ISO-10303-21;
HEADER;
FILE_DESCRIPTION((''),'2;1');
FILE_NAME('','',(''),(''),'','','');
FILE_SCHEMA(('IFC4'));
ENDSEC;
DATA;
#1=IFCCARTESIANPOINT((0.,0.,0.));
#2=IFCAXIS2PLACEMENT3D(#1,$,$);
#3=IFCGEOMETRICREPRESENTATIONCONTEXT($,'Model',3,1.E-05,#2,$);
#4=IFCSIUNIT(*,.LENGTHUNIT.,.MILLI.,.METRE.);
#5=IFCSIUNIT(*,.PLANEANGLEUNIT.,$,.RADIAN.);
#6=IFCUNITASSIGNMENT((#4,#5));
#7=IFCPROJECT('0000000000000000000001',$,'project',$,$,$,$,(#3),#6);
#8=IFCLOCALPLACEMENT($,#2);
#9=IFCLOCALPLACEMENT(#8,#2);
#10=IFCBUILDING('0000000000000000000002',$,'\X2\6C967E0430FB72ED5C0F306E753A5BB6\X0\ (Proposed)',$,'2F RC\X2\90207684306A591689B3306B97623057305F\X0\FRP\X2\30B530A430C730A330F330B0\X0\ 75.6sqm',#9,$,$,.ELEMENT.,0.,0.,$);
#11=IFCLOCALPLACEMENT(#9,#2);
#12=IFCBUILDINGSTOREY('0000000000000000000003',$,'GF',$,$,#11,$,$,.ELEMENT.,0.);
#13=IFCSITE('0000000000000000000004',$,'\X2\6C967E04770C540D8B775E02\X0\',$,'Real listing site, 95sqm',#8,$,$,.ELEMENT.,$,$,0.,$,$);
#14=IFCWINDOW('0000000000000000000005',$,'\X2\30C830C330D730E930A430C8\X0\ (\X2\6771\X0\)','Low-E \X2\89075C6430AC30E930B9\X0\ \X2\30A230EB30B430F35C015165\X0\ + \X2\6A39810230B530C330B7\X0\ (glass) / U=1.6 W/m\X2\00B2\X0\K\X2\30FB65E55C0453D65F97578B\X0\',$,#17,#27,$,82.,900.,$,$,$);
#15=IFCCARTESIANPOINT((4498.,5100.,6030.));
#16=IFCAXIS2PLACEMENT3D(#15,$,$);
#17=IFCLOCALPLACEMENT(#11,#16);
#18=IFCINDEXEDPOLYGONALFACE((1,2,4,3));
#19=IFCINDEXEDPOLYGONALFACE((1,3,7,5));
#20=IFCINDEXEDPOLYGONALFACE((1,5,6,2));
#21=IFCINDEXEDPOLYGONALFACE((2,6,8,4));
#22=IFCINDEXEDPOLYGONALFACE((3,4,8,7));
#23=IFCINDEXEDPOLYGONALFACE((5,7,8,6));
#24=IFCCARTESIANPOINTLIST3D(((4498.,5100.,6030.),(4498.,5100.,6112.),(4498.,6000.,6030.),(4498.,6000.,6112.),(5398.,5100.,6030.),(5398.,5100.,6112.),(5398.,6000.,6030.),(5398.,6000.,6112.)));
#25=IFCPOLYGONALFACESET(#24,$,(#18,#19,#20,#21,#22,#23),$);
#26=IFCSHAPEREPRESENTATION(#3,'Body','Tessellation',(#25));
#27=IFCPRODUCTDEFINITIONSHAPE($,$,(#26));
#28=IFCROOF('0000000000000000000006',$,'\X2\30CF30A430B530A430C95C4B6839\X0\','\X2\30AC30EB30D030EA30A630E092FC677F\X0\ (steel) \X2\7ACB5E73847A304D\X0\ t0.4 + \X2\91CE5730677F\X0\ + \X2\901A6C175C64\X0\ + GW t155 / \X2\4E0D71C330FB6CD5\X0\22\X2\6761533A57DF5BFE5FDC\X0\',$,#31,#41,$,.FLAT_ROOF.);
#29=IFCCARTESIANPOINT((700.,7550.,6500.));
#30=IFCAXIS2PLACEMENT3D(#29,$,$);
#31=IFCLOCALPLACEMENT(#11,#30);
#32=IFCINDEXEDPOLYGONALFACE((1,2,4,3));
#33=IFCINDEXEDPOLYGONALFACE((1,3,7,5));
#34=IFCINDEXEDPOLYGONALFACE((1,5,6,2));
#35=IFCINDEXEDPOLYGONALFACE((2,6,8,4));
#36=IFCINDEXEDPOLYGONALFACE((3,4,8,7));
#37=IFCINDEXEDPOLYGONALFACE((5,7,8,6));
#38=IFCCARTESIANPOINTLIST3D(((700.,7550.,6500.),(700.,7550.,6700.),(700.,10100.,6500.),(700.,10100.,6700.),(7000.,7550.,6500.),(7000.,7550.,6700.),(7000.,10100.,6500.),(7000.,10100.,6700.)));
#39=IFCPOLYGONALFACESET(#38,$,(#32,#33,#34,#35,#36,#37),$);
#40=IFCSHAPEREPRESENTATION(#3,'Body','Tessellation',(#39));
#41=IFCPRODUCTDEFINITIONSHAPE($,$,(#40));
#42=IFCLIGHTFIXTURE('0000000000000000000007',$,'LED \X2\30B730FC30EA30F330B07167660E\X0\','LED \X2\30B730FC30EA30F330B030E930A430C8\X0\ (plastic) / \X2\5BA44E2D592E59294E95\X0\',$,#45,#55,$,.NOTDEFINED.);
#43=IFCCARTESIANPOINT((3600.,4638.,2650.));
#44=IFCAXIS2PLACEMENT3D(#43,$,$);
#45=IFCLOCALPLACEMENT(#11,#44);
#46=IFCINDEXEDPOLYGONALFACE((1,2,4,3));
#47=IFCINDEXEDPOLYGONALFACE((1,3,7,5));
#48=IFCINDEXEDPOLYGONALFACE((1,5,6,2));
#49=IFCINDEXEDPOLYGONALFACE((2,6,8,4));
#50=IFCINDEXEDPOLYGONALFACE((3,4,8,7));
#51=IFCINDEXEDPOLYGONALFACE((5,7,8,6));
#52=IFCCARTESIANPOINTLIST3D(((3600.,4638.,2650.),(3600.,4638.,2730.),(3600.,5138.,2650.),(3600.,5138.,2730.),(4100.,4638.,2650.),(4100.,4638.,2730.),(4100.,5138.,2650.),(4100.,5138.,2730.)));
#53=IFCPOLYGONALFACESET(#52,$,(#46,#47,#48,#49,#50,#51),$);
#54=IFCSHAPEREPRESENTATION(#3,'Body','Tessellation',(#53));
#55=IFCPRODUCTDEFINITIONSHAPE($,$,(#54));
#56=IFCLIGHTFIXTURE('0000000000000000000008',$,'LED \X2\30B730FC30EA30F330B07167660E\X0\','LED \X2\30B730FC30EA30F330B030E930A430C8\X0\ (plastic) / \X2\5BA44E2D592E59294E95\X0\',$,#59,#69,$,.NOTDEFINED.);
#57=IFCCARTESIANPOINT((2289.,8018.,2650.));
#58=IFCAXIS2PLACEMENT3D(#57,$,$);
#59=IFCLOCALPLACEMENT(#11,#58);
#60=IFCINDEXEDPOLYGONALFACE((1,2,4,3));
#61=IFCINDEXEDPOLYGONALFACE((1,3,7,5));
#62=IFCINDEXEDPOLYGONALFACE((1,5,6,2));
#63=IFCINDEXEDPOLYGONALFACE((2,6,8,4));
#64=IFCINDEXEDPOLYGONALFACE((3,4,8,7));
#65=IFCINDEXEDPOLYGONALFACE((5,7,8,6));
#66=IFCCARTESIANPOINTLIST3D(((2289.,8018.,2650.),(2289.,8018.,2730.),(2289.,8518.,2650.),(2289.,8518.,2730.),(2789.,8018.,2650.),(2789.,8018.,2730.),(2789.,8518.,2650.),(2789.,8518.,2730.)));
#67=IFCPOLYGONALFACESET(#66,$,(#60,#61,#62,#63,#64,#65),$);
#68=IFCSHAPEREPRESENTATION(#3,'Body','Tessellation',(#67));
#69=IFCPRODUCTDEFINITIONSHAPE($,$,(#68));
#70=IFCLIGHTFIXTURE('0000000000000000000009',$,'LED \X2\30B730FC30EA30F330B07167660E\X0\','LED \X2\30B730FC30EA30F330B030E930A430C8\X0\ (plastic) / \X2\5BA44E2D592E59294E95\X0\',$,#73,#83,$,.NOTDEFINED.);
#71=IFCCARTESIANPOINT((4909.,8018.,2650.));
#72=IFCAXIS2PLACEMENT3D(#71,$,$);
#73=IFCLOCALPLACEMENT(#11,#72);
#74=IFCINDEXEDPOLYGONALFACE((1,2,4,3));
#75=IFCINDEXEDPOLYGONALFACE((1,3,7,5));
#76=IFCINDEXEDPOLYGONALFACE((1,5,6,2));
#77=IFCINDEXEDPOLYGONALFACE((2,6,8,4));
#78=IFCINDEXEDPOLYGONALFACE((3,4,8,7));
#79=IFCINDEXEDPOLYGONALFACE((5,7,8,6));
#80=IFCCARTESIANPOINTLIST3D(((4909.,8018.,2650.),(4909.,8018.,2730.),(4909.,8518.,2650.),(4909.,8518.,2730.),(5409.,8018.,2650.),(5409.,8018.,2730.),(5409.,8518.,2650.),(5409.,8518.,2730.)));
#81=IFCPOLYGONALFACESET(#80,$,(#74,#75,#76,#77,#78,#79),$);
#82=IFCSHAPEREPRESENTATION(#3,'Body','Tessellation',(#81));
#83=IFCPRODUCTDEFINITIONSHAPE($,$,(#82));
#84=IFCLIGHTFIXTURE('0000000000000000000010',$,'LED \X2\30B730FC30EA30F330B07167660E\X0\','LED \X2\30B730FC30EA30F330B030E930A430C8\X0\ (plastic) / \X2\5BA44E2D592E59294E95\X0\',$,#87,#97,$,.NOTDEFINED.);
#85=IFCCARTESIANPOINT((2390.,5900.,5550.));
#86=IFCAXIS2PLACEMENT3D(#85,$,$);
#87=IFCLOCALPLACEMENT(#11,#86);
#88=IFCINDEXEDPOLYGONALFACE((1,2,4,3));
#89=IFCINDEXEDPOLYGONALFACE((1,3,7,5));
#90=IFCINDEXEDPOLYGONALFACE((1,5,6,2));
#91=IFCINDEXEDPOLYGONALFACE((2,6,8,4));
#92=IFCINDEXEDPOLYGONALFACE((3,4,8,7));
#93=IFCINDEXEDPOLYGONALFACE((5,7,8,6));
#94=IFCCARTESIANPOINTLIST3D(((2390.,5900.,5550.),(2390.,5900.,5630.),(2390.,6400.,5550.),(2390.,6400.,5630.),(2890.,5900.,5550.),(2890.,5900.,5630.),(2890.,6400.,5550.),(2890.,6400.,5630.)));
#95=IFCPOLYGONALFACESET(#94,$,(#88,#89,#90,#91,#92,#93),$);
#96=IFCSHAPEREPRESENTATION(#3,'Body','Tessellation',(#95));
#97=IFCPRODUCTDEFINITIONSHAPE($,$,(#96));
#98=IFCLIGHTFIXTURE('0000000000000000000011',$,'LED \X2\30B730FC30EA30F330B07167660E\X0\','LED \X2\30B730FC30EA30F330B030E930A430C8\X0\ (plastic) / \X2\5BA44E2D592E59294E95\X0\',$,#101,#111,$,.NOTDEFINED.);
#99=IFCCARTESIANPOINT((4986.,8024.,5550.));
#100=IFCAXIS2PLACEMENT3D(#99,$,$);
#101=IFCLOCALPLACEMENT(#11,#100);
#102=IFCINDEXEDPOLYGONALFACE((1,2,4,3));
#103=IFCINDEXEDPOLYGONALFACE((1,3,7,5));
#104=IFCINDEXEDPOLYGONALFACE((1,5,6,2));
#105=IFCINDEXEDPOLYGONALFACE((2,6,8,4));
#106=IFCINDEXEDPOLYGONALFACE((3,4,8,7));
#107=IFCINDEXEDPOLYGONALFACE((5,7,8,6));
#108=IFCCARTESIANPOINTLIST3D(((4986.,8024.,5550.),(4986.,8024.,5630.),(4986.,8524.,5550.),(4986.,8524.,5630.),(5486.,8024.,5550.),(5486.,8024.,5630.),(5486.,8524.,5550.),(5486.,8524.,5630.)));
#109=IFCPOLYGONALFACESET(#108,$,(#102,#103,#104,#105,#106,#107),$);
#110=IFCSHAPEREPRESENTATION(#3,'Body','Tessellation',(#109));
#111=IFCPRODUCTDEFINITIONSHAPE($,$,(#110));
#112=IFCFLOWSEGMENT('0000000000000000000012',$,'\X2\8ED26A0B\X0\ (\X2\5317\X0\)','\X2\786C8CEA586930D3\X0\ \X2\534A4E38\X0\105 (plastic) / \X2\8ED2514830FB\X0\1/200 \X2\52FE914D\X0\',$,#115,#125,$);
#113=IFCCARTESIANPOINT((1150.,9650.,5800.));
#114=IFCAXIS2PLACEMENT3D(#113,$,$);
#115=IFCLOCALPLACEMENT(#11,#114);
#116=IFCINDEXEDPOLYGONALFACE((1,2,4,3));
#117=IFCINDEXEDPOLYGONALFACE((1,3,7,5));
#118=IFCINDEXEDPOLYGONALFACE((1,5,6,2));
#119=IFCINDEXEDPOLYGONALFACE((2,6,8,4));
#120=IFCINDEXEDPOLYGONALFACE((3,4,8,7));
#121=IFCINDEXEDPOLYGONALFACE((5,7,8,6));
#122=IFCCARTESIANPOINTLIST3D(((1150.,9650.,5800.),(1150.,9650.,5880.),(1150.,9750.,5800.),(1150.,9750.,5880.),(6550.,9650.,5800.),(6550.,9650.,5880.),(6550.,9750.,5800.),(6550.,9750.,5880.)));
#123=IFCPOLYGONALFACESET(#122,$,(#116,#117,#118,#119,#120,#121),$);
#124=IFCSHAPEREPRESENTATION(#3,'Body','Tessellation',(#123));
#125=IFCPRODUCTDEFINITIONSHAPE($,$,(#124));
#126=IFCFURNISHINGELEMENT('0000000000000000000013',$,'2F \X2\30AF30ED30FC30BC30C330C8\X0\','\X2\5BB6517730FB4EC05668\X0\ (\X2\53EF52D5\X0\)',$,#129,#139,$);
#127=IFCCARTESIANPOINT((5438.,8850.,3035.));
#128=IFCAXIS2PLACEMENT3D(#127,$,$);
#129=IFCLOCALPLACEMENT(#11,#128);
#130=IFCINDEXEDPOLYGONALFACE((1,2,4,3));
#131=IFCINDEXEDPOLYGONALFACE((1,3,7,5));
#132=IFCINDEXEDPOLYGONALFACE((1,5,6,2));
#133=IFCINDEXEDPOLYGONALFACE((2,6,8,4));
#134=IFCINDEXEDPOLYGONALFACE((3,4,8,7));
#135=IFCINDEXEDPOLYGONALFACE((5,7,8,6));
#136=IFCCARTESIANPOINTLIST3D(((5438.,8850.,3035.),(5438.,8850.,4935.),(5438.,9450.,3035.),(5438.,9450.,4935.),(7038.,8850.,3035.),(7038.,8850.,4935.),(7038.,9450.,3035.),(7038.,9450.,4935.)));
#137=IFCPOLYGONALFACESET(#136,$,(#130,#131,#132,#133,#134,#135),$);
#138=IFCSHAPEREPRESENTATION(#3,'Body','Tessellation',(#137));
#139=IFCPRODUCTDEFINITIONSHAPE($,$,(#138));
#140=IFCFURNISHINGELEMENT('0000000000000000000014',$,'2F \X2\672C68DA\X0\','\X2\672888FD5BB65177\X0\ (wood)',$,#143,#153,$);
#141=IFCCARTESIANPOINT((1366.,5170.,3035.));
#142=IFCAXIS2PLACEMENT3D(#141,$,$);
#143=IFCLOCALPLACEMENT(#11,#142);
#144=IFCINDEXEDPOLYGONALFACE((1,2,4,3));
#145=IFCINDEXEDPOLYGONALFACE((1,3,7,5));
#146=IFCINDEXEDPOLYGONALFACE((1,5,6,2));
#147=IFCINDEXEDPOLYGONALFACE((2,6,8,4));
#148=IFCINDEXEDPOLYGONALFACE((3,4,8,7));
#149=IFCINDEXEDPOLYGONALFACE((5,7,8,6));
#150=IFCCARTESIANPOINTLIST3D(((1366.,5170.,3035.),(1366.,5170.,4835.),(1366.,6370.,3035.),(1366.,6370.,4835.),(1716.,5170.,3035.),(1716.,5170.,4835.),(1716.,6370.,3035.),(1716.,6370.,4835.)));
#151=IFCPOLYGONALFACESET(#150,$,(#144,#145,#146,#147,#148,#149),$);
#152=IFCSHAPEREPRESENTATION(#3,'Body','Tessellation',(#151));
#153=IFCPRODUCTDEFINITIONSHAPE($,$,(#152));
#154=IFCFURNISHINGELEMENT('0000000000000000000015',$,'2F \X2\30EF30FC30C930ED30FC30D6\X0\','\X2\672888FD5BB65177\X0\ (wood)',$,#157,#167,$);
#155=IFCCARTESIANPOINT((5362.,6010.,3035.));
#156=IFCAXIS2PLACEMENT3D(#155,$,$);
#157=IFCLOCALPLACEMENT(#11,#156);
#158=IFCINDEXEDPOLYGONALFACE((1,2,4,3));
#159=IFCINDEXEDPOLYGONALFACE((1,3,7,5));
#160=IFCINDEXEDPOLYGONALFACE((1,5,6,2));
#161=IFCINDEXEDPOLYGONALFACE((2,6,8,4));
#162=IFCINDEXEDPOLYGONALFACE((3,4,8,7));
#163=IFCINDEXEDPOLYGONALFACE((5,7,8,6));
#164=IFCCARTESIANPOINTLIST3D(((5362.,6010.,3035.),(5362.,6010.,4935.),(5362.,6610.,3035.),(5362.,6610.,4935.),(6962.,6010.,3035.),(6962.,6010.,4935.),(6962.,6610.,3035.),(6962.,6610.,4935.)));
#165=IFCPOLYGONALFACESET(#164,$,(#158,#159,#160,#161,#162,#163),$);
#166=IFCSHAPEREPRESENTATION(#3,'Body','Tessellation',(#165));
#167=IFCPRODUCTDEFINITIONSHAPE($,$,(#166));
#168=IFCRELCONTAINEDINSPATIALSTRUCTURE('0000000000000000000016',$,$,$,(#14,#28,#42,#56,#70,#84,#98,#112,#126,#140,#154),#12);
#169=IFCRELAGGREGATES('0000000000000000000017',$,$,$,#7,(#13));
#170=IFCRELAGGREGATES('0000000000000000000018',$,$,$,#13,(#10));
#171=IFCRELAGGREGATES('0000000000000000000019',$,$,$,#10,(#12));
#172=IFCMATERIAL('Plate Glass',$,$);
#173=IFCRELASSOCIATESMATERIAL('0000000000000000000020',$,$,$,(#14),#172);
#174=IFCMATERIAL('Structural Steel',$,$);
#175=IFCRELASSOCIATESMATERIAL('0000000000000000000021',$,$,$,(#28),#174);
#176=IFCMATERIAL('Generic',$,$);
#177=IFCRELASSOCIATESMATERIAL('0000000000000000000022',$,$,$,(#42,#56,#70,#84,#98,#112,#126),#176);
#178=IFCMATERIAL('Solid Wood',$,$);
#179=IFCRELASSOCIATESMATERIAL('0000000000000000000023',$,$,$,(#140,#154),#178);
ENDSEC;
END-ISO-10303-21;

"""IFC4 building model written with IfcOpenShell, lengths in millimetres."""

from ifc_helpers import new_model, si_unit, frame, frame_2d, origin, place, context, project, spatial, rectangle, extrude, material, element, save


model = new_model("IFC4")

# Units and contexts
model_context = context("Model", 3, precision=1e-05, world=origin())
ifc_project = project(units=[si_unit("LENGTHUNIT", "METRE", prefix="MILLI"), si_unit("PLANEANGLEUNIT", "RADIAN")], contexts=[model_context])

# Site, building, storey
site_placement = place(None, origin())
site = spatial("IfcSite", under=ifc_project, at=site_placement, Name="沖縄県名護市", ObjectType="Real listing site, 95sqm", CompositionType="ELEMENT", RefElevation=0.0)
building_placement = place(site_placement, origin())
building = spatial("IfcBuilding", under=site, at=building_placement, Name="沖縄・狭小の町家 (Proposed)", ObjectType="2F RC造的な外観に面したFRPサイディング 75.6sqm", CompositionType="ELEMENT", ElevationOfRefHeight=0.0, ElevationOfTerrain=0.0)
storey_placement = place(building_placement, origin())
storey = spatial("IfcBuildingStorey", under=building, at=storey_placement, Name="GF", CompositionType="ELEMENT", Elevation=0.0)

# Shared definitions
ifc_material_1 = material(Name="Solid Wood")

# Shared definitions
ifc_material_2 = material(Name="Plate Glass")

# Window
window_1_placement = place(storey_placement, frame((4498.0, 5100.0, 6030.0)))
element("IfcWindow", 1, at=window_1_placement, inside=storey, material=ifc_material_2, Name="トップライト (東)", Description="Low-E 複層ガラス アルゴン封入 + 樹脂サッシ (glass) / U=1.6 W/m²K・日射取得型", OverallHeight=82.0, OverallWidth=900.0, context=model_context, shape_type="SweptSolid", body=[
    extrude(rectangle(XDim=900.0, YDim=900.0, at=frame_2d((450.0, 450.0))), frame((4498.0, 5100.0, 6030.0)), (0.0, 0.0, 1.0), 82.0),
])

# Roof
ifc_material_3 = material(Name="Structural Steel")
roof_placement = place(storey_placement, frame((700.0, 7550.0, 6500.0)))
element("IfcRoof", 2, at=roof_placement, inside=storey, material=ifc_material_3, Name="ハイサイド屋根", Description="ガルバリウム鋼板 (steel) 立平葺き t0.4 + 野地板 + 通気層 + GW t155 / 不燃・法22条区域対応", PredefinedType="FLAT_ROOF", context=model_context, shape_type="SweptSolid", body=[
    extrude(rectangle(XDim=6300.0, YDim=2550.0, at=frame_2d((3150.0, 1275.0))), frame((700.0, 7550.0, 6500.0)), (0.0, 0.0, 1.0), 200.0),
])

# Light fixtures
ifc_material_4 = material(Name="Generic")
light_fixture_1_placement = place(storey_placement, frame((3600.0, 4638.0, 2650.0)))
element("IfcLightFixture", 3, at=light_fixture_1_placement, inside=storey, material=ifc_material_4, Name="LED シーリング照明", Description="LED シーリングライト (plastic) / 室中央天井", PredefinedType="NOTDEFINED", context=model_context, shape_type="SweptSolid", body=[
    extrude(rectangle(XDim=500.0, YDim=500.0, at=frame_2d((250.0, 250.0))), frame((3600.0, 4638.0, 2650.0)), (0.0, 0.0, 1.0), 80.0),
])
light_fixture_2_placement = place(storey_placement, frame((2289.0, 8018.0, 2650.0)))
element("IfcLightFixture", 4, at=light_fixture_2_placement, inside=storey, material=ifc_material_4, Name="LED シーリング照明", Description="LED シーリングライト (plastic) / 室中央天井", PredefinedType="NOTDEFINED", context=model_context, shape_type="SweptSolid", body=[
    extrude(rectangle(XDim=500.0, YDim=500.0, at=frame_2d((250.0, 250.0))), frame((2289.0, 8018.0, 2650.0)), (0.0, 0.0, 1.0), 80.0),
])
light_fixture_3_placement = place(storey_placement, frame((4909.0, 8018.0, 2650.0)))
element("IfcLightFixture", 5, at=light_fixture_3_placement, inside=storey, material=ifc_material_4, Name="LED シーリング照明", Description="LED シーリングライト (plastic) / 室中央天井", PredefinedType="NOTDEFINED", context=model_context, shape_type="SweptSolid", body=[
    extrude(rectangle(XDim=500.0, YDim=500.0, at=frame_2d((250.0, 250.0))), frame((4909.0, 8018.0, 2650.0)), (0.0, 0.0, 1.0), 80.0),
])
light_fixture_4_placement = place(storey_placement, frame((2390.0, 5900.0, 5550.0)))
element("IfcLightFixture", 6, at=light_fixture_4_placement, inside=storey, material=ifc_material_4, Name="LED シーリング照明", Description="LED シーリングライト (plastic) / 室中央天井", PredefinedType="NOTDEFINED", context=model_context, shape_type="SweptSolid", body=[
    extrude(rectangle(XDim=500.0, YDim=500.0, at=frame_2d((250.0, 250.0))), frame((2390.0, 5900.0, 5550.0)), (0.0, 0.0, 1.0), 80.0),
])
light_fixture_5_placement = place(storey_placement, frame((4986.0, 8024.0, 5550.0)))
element("IfcLightFixture", 7, at=light_fixture_5_placement, inside=storey, material=ifc_material_4, Name="LED シーリング照明", Description="LED シーリングライト (plastic) / 室中央天井", PredefinedType="NOTDEFINED", context=model_context, shape_type="SweptSolid", body=[
    extrude(rectangle(XDim=500.0, YDim=500.0, at=frame_2d((250.0, 250.0))), frame((4986.0, 8024.0, 5550.0)), (0.0, 0.0, 1.0), 80.0),
])

# Flow segment
flow_segment_placement = place(storey_placement, frame((1150.0, 9650.0, 5800.0)))
element("IfcFlowSegment", 8, at=flow_segment_placement, inside=storey, material=ifc_material_4, Name="軒樋 (北)", Description="硬質塩ビ 半丸105 (plastic) / 軒先・1/200 勾配", context=model_context, shape_type="SweptSolid", body=[
    extrude(rectangle(XDim=5400.0, YDim=100.0, at=frame_2d((2700.0, 50.0))), frame((1150.0, 9650.0, 5800.0)), (0.0, 0.0, 1.0), 80.0),
])

# Furnishing elements
furnishing_1_placement = place(storey_placement, frame((5438.0, 8850.0, 3035.0)))
element("IfcFurnishingElement", 9, at=furnishing_1_placement, inside=storey, material=ifc_material_4, Name="2F クローゼット", Description="家具・什器 (可動)", context=model_context, shape_type="SweptSolid", body=[
    extrude(rectangle(XDim=1600.0, YDim=600.0, at=frame_2d((800.0, 300.0))), frame((5438.0, 8850.0, 3035.0)), (0.0, 0.0, 1.0), 1900.0),
])
furnishing_2_placement = place(storey_placement, frame((1366.0, 5170.0, 3035.0)))
element("IfcFurnishingElement", 10, at=furnishing_2_placement, inside=storey, material=ifc_material_1, Name="2F 本棚", Description="木製家具 (wood)", context=model_context, shape_type="SweptSolid", body=[
    extrude(rectangle(XDim=350.0, YDim=1200.0, at=frame_2d((175.0, 600.0))), frame((1366.0, 5170.0, 3035.0)), (0.0, 0.0, 1.0), 1800.0),
])
furnishing_3_placement = place(storey_placement, frame((5362.0, 6010.0, 3035.0)))
element("IfcFurnishingElement", 11, at=furnishing_3_placement, inside=storey, material=ifc_material_1, Name="2F ワードローブ", Description="木製家具 (wood)", context=model_context, shape_type="SweptSolid", body=[
    extrude(rectangle(XDim=1600.0, YDim=600.0, at=frame_2d((800.0, 300.0))), frame((5362.0, 6010.0, 3035.0)), (0.0, 0.0, 1.0), 1900.0),
])

save(model, "model.ifc")
